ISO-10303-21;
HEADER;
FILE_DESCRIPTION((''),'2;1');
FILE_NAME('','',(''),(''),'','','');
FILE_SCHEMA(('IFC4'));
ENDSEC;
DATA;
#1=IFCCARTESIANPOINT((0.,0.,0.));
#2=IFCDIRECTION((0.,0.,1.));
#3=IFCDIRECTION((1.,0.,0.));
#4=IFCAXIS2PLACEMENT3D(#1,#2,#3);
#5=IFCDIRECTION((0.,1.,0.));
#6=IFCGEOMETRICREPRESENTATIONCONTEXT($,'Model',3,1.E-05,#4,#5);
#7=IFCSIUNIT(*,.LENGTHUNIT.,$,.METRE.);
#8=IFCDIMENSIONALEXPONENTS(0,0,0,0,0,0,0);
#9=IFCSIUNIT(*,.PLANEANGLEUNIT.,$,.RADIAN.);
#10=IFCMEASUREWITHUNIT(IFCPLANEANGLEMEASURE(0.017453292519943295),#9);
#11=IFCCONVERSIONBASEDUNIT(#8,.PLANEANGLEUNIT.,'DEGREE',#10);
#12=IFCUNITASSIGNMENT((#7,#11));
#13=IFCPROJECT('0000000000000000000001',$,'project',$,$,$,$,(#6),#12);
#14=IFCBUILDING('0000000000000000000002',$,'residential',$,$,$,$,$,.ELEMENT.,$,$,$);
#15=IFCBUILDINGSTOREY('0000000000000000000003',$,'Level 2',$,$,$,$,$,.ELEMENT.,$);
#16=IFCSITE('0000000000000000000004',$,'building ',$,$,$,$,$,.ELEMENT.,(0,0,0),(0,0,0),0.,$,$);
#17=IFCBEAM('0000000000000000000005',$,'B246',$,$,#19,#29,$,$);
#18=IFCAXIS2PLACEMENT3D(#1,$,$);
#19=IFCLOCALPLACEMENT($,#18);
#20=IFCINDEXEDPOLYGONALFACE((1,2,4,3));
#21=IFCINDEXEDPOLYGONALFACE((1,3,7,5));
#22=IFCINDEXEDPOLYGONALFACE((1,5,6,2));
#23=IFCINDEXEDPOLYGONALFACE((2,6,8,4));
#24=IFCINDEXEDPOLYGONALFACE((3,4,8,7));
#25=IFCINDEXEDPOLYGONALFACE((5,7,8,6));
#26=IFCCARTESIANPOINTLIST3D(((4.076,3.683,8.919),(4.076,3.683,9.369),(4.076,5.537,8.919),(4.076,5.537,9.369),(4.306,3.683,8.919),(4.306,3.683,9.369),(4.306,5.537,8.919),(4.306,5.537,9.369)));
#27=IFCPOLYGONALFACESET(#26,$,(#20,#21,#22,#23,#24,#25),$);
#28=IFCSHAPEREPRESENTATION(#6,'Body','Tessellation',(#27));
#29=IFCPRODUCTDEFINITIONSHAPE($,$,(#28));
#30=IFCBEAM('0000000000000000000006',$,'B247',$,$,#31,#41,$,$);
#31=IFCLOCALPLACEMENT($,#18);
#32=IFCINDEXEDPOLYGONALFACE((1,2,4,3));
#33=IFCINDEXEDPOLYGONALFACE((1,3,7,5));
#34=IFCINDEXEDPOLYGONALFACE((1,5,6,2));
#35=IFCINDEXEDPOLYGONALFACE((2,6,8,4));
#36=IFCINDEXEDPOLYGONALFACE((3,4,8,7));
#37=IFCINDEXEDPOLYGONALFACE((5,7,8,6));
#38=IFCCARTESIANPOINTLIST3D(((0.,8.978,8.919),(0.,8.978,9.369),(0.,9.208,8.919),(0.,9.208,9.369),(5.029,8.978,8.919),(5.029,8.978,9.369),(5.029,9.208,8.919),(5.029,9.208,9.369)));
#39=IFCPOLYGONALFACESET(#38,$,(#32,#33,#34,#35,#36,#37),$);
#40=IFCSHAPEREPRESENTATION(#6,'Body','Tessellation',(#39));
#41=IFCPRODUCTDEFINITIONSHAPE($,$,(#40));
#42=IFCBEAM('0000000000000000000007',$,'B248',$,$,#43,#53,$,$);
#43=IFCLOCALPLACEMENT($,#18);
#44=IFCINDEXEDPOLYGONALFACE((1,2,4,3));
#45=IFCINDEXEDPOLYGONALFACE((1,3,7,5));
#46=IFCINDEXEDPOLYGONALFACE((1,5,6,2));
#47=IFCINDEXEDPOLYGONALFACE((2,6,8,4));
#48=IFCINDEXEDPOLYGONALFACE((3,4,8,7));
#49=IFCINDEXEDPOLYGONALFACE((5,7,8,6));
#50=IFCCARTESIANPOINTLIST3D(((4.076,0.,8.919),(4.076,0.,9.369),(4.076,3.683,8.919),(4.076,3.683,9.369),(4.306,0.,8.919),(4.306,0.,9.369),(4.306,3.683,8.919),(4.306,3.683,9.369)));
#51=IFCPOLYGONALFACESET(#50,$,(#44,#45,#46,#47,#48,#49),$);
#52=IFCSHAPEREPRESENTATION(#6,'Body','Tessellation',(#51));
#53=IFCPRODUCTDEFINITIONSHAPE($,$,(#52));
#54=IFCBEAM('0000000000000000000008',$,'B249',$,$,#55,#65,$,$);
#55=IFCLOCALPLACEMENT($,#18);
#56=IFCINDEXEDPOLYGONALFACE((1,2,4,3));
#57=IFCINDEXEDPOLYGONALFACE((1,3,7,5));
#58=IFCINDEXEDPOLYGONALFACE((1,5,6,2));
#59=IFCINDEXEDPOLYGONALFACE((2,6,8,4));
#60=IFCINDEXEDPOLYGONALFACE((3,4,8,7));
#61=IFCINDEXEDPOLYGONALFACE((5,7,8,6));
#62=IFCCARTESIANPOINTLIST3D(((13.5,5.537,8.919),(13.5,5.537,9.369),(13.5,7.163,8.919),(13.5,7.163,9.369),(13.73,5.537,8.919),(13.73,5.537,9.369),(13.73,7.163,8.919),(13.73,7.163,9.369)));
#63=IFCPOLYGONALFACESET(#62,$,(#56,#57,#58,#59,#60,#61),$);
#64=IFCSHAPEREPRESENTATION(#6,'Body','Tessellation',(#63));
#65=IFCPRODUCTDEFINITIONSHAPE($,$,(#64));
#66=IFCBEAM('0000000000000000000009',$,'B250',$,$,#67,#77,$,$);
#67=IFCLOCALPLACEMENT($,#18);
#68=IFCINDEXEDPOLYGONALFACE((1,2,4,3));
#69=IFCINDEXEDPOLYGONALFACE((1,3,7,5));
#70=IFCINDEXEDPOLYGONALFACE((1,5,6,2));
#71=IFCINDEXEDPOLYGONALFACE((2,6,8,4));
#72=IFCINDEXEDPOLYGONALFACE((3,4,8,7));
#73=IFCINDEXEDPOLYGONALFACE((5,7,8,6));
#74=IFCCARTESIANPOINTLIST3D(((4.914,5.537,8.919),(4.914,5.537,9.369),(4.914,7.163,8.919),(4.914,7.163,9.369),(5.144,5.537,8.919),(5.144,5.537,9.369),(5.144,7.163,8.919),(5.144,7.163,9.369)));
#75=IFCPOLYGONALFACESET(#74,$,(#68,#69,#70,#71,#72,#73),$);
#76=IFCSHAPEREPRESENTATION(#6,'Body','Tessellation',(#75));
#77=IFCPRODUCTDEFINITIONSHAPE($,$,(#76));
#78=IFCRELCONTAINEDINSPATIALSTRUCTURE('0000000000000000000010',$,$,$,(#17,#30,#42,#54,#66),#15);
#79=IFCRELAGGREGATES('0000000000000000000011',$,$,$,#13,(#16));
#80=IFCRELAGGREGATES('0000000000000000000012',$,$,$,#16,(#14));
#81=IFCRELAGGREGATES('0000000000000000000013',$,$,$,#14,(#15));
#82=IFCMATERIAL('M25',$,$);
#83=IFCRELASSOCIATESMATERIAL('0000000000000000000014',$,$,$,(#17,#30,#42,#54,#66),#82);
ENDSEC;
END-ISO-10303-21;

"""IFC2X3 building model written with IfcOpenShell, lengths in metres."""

from ifc_helpers import new_model, entity, si_unit, converted_unit, direction, frame, frame_2d, origin_with_axes, place, context, project, spatial, rectangle, extrude, material, element, save


model = new_model("IFC2X3")

# Units and contexts
model_context = context("Model", 3, precision=1e-05, world=origin_with_axes(), true_north=direction((0.0, 1.0, 0.0)))
ifc_project = project(units=[si_unit("LENGTHUNIT", "METRE"), converted_unit("PLANEANGLEUNIT", "DEGREE", entity("IfcPlaneAngleMeasure", 0.017453292519943295), si_unit("PLANEANGLEUNIT", "RADIAN"), dimensions=[0, 0, 0, 0, 0, 0, 0])], contexts=[model_context])

# Site, building, storey
site = spatial("IfcSite", under=ifc_project, Name="building ", CompositionType="ELEMENT", RefLatitude=(0, 0, 0), RefLongitude=(0, 0, 0), RefElevation=0.0)
building = spatial("IfcBuilding", under=site, Name="residential", CompositionType="ELEMENT")
storey = spatial("IfcBuildingStorey", under=building, Name="Level 2", CompositionType="ELEMENT")

# Beams
ifc_material = material(Name="M25")
placement = place(None, origin_with_axes())
element("IfcBeam", 1, at=placement, inside=storey, material=ifc_material, Name="B246", context=model_context, shape_type="SweptSolid", body=[
    extrude(rectangle(XDim=0.23, YDim=0.45, at=frame_2d((0.0, 0.0), x_axis=(0.0, 1.0, 0.0))), frame((4.191, 3.683, 9.144), z_axis=(0.0, 1.0, 0.0), x_axis=(0.0, 0.0, -1.0)), (0.0, 0.0, 1.0), 1.854),
])
element("IfcBeam", 2, at=placement, inside=storey, material=ifc_material, Name="B247", context=model_context, shape_type="SweptSolid", body=[
    extrude(rectangle(XDim=0.23, YDim=0.45, at=frame_2d((0.0, 0.0), x_axis=(0.0, 1.0, 0.0))), frame((0.0, 9.093, 9.144), z_axis=(1.0, 0.0, 0.0), x_axis=(0.0, 0.0, -1.0)), (0.0, 0.0, 1.0), 5.029),
])
element("IfcBeam", 3, at=placement, inside=storey, material=ifc_material, Name="B248", context=model_context, shape_type="SweptSolid", body=[
    extrude(rectangle(XDim=0.23, YDim=0.45, at=frame_2d((0.0, 0.0), x_axis=(0.0, 1.0, 0.0))), frame((4.191, 0.0, 9.144), z_axis=(0.0, 1.0, 0.0), x_axis=(0.0, 0.0, -1.0)), (0.0, 0.0, 1.0), 3.683),
])
element("IfcBeam", 4, at=placement, inside=storey, material=ifc_material, Name="B249", context=model_context, shape_type="SweptSolid", body=[
    extrude(rectangle(XDim=0.23, YDim=0.45, at=frame_2d((0.0, 0.0), x_axis=(0.0, 1.0, 0.0))), frame((13.615, 5.537, 9.144), z_axis=(0.0, 1.0, 0.0), x_axis=(0.0, 0.0, -1.0)), (0.0, 0.0, 1.0), 1.626),
])
element("IfcBeam", 5, at=placement, inside=storey, material=ifc_material, Name="B250", context=model_context, shape_type="SweptSolid", body=[
    extrude(rectangle(XDim=0.23, YDim=0.45, at=frame_2d((0.0, 0.0), x_axis=(0.0, 1.0, 0.0))), frame((5.029, 5.537, 9.144), z_axis=(0.0, 1.0, 0.0), x_axis=(0.0, 0.0, -1.0)), (0.0, 0.0, 1.0), 1.626),
])

save(model, "model.ifc")
